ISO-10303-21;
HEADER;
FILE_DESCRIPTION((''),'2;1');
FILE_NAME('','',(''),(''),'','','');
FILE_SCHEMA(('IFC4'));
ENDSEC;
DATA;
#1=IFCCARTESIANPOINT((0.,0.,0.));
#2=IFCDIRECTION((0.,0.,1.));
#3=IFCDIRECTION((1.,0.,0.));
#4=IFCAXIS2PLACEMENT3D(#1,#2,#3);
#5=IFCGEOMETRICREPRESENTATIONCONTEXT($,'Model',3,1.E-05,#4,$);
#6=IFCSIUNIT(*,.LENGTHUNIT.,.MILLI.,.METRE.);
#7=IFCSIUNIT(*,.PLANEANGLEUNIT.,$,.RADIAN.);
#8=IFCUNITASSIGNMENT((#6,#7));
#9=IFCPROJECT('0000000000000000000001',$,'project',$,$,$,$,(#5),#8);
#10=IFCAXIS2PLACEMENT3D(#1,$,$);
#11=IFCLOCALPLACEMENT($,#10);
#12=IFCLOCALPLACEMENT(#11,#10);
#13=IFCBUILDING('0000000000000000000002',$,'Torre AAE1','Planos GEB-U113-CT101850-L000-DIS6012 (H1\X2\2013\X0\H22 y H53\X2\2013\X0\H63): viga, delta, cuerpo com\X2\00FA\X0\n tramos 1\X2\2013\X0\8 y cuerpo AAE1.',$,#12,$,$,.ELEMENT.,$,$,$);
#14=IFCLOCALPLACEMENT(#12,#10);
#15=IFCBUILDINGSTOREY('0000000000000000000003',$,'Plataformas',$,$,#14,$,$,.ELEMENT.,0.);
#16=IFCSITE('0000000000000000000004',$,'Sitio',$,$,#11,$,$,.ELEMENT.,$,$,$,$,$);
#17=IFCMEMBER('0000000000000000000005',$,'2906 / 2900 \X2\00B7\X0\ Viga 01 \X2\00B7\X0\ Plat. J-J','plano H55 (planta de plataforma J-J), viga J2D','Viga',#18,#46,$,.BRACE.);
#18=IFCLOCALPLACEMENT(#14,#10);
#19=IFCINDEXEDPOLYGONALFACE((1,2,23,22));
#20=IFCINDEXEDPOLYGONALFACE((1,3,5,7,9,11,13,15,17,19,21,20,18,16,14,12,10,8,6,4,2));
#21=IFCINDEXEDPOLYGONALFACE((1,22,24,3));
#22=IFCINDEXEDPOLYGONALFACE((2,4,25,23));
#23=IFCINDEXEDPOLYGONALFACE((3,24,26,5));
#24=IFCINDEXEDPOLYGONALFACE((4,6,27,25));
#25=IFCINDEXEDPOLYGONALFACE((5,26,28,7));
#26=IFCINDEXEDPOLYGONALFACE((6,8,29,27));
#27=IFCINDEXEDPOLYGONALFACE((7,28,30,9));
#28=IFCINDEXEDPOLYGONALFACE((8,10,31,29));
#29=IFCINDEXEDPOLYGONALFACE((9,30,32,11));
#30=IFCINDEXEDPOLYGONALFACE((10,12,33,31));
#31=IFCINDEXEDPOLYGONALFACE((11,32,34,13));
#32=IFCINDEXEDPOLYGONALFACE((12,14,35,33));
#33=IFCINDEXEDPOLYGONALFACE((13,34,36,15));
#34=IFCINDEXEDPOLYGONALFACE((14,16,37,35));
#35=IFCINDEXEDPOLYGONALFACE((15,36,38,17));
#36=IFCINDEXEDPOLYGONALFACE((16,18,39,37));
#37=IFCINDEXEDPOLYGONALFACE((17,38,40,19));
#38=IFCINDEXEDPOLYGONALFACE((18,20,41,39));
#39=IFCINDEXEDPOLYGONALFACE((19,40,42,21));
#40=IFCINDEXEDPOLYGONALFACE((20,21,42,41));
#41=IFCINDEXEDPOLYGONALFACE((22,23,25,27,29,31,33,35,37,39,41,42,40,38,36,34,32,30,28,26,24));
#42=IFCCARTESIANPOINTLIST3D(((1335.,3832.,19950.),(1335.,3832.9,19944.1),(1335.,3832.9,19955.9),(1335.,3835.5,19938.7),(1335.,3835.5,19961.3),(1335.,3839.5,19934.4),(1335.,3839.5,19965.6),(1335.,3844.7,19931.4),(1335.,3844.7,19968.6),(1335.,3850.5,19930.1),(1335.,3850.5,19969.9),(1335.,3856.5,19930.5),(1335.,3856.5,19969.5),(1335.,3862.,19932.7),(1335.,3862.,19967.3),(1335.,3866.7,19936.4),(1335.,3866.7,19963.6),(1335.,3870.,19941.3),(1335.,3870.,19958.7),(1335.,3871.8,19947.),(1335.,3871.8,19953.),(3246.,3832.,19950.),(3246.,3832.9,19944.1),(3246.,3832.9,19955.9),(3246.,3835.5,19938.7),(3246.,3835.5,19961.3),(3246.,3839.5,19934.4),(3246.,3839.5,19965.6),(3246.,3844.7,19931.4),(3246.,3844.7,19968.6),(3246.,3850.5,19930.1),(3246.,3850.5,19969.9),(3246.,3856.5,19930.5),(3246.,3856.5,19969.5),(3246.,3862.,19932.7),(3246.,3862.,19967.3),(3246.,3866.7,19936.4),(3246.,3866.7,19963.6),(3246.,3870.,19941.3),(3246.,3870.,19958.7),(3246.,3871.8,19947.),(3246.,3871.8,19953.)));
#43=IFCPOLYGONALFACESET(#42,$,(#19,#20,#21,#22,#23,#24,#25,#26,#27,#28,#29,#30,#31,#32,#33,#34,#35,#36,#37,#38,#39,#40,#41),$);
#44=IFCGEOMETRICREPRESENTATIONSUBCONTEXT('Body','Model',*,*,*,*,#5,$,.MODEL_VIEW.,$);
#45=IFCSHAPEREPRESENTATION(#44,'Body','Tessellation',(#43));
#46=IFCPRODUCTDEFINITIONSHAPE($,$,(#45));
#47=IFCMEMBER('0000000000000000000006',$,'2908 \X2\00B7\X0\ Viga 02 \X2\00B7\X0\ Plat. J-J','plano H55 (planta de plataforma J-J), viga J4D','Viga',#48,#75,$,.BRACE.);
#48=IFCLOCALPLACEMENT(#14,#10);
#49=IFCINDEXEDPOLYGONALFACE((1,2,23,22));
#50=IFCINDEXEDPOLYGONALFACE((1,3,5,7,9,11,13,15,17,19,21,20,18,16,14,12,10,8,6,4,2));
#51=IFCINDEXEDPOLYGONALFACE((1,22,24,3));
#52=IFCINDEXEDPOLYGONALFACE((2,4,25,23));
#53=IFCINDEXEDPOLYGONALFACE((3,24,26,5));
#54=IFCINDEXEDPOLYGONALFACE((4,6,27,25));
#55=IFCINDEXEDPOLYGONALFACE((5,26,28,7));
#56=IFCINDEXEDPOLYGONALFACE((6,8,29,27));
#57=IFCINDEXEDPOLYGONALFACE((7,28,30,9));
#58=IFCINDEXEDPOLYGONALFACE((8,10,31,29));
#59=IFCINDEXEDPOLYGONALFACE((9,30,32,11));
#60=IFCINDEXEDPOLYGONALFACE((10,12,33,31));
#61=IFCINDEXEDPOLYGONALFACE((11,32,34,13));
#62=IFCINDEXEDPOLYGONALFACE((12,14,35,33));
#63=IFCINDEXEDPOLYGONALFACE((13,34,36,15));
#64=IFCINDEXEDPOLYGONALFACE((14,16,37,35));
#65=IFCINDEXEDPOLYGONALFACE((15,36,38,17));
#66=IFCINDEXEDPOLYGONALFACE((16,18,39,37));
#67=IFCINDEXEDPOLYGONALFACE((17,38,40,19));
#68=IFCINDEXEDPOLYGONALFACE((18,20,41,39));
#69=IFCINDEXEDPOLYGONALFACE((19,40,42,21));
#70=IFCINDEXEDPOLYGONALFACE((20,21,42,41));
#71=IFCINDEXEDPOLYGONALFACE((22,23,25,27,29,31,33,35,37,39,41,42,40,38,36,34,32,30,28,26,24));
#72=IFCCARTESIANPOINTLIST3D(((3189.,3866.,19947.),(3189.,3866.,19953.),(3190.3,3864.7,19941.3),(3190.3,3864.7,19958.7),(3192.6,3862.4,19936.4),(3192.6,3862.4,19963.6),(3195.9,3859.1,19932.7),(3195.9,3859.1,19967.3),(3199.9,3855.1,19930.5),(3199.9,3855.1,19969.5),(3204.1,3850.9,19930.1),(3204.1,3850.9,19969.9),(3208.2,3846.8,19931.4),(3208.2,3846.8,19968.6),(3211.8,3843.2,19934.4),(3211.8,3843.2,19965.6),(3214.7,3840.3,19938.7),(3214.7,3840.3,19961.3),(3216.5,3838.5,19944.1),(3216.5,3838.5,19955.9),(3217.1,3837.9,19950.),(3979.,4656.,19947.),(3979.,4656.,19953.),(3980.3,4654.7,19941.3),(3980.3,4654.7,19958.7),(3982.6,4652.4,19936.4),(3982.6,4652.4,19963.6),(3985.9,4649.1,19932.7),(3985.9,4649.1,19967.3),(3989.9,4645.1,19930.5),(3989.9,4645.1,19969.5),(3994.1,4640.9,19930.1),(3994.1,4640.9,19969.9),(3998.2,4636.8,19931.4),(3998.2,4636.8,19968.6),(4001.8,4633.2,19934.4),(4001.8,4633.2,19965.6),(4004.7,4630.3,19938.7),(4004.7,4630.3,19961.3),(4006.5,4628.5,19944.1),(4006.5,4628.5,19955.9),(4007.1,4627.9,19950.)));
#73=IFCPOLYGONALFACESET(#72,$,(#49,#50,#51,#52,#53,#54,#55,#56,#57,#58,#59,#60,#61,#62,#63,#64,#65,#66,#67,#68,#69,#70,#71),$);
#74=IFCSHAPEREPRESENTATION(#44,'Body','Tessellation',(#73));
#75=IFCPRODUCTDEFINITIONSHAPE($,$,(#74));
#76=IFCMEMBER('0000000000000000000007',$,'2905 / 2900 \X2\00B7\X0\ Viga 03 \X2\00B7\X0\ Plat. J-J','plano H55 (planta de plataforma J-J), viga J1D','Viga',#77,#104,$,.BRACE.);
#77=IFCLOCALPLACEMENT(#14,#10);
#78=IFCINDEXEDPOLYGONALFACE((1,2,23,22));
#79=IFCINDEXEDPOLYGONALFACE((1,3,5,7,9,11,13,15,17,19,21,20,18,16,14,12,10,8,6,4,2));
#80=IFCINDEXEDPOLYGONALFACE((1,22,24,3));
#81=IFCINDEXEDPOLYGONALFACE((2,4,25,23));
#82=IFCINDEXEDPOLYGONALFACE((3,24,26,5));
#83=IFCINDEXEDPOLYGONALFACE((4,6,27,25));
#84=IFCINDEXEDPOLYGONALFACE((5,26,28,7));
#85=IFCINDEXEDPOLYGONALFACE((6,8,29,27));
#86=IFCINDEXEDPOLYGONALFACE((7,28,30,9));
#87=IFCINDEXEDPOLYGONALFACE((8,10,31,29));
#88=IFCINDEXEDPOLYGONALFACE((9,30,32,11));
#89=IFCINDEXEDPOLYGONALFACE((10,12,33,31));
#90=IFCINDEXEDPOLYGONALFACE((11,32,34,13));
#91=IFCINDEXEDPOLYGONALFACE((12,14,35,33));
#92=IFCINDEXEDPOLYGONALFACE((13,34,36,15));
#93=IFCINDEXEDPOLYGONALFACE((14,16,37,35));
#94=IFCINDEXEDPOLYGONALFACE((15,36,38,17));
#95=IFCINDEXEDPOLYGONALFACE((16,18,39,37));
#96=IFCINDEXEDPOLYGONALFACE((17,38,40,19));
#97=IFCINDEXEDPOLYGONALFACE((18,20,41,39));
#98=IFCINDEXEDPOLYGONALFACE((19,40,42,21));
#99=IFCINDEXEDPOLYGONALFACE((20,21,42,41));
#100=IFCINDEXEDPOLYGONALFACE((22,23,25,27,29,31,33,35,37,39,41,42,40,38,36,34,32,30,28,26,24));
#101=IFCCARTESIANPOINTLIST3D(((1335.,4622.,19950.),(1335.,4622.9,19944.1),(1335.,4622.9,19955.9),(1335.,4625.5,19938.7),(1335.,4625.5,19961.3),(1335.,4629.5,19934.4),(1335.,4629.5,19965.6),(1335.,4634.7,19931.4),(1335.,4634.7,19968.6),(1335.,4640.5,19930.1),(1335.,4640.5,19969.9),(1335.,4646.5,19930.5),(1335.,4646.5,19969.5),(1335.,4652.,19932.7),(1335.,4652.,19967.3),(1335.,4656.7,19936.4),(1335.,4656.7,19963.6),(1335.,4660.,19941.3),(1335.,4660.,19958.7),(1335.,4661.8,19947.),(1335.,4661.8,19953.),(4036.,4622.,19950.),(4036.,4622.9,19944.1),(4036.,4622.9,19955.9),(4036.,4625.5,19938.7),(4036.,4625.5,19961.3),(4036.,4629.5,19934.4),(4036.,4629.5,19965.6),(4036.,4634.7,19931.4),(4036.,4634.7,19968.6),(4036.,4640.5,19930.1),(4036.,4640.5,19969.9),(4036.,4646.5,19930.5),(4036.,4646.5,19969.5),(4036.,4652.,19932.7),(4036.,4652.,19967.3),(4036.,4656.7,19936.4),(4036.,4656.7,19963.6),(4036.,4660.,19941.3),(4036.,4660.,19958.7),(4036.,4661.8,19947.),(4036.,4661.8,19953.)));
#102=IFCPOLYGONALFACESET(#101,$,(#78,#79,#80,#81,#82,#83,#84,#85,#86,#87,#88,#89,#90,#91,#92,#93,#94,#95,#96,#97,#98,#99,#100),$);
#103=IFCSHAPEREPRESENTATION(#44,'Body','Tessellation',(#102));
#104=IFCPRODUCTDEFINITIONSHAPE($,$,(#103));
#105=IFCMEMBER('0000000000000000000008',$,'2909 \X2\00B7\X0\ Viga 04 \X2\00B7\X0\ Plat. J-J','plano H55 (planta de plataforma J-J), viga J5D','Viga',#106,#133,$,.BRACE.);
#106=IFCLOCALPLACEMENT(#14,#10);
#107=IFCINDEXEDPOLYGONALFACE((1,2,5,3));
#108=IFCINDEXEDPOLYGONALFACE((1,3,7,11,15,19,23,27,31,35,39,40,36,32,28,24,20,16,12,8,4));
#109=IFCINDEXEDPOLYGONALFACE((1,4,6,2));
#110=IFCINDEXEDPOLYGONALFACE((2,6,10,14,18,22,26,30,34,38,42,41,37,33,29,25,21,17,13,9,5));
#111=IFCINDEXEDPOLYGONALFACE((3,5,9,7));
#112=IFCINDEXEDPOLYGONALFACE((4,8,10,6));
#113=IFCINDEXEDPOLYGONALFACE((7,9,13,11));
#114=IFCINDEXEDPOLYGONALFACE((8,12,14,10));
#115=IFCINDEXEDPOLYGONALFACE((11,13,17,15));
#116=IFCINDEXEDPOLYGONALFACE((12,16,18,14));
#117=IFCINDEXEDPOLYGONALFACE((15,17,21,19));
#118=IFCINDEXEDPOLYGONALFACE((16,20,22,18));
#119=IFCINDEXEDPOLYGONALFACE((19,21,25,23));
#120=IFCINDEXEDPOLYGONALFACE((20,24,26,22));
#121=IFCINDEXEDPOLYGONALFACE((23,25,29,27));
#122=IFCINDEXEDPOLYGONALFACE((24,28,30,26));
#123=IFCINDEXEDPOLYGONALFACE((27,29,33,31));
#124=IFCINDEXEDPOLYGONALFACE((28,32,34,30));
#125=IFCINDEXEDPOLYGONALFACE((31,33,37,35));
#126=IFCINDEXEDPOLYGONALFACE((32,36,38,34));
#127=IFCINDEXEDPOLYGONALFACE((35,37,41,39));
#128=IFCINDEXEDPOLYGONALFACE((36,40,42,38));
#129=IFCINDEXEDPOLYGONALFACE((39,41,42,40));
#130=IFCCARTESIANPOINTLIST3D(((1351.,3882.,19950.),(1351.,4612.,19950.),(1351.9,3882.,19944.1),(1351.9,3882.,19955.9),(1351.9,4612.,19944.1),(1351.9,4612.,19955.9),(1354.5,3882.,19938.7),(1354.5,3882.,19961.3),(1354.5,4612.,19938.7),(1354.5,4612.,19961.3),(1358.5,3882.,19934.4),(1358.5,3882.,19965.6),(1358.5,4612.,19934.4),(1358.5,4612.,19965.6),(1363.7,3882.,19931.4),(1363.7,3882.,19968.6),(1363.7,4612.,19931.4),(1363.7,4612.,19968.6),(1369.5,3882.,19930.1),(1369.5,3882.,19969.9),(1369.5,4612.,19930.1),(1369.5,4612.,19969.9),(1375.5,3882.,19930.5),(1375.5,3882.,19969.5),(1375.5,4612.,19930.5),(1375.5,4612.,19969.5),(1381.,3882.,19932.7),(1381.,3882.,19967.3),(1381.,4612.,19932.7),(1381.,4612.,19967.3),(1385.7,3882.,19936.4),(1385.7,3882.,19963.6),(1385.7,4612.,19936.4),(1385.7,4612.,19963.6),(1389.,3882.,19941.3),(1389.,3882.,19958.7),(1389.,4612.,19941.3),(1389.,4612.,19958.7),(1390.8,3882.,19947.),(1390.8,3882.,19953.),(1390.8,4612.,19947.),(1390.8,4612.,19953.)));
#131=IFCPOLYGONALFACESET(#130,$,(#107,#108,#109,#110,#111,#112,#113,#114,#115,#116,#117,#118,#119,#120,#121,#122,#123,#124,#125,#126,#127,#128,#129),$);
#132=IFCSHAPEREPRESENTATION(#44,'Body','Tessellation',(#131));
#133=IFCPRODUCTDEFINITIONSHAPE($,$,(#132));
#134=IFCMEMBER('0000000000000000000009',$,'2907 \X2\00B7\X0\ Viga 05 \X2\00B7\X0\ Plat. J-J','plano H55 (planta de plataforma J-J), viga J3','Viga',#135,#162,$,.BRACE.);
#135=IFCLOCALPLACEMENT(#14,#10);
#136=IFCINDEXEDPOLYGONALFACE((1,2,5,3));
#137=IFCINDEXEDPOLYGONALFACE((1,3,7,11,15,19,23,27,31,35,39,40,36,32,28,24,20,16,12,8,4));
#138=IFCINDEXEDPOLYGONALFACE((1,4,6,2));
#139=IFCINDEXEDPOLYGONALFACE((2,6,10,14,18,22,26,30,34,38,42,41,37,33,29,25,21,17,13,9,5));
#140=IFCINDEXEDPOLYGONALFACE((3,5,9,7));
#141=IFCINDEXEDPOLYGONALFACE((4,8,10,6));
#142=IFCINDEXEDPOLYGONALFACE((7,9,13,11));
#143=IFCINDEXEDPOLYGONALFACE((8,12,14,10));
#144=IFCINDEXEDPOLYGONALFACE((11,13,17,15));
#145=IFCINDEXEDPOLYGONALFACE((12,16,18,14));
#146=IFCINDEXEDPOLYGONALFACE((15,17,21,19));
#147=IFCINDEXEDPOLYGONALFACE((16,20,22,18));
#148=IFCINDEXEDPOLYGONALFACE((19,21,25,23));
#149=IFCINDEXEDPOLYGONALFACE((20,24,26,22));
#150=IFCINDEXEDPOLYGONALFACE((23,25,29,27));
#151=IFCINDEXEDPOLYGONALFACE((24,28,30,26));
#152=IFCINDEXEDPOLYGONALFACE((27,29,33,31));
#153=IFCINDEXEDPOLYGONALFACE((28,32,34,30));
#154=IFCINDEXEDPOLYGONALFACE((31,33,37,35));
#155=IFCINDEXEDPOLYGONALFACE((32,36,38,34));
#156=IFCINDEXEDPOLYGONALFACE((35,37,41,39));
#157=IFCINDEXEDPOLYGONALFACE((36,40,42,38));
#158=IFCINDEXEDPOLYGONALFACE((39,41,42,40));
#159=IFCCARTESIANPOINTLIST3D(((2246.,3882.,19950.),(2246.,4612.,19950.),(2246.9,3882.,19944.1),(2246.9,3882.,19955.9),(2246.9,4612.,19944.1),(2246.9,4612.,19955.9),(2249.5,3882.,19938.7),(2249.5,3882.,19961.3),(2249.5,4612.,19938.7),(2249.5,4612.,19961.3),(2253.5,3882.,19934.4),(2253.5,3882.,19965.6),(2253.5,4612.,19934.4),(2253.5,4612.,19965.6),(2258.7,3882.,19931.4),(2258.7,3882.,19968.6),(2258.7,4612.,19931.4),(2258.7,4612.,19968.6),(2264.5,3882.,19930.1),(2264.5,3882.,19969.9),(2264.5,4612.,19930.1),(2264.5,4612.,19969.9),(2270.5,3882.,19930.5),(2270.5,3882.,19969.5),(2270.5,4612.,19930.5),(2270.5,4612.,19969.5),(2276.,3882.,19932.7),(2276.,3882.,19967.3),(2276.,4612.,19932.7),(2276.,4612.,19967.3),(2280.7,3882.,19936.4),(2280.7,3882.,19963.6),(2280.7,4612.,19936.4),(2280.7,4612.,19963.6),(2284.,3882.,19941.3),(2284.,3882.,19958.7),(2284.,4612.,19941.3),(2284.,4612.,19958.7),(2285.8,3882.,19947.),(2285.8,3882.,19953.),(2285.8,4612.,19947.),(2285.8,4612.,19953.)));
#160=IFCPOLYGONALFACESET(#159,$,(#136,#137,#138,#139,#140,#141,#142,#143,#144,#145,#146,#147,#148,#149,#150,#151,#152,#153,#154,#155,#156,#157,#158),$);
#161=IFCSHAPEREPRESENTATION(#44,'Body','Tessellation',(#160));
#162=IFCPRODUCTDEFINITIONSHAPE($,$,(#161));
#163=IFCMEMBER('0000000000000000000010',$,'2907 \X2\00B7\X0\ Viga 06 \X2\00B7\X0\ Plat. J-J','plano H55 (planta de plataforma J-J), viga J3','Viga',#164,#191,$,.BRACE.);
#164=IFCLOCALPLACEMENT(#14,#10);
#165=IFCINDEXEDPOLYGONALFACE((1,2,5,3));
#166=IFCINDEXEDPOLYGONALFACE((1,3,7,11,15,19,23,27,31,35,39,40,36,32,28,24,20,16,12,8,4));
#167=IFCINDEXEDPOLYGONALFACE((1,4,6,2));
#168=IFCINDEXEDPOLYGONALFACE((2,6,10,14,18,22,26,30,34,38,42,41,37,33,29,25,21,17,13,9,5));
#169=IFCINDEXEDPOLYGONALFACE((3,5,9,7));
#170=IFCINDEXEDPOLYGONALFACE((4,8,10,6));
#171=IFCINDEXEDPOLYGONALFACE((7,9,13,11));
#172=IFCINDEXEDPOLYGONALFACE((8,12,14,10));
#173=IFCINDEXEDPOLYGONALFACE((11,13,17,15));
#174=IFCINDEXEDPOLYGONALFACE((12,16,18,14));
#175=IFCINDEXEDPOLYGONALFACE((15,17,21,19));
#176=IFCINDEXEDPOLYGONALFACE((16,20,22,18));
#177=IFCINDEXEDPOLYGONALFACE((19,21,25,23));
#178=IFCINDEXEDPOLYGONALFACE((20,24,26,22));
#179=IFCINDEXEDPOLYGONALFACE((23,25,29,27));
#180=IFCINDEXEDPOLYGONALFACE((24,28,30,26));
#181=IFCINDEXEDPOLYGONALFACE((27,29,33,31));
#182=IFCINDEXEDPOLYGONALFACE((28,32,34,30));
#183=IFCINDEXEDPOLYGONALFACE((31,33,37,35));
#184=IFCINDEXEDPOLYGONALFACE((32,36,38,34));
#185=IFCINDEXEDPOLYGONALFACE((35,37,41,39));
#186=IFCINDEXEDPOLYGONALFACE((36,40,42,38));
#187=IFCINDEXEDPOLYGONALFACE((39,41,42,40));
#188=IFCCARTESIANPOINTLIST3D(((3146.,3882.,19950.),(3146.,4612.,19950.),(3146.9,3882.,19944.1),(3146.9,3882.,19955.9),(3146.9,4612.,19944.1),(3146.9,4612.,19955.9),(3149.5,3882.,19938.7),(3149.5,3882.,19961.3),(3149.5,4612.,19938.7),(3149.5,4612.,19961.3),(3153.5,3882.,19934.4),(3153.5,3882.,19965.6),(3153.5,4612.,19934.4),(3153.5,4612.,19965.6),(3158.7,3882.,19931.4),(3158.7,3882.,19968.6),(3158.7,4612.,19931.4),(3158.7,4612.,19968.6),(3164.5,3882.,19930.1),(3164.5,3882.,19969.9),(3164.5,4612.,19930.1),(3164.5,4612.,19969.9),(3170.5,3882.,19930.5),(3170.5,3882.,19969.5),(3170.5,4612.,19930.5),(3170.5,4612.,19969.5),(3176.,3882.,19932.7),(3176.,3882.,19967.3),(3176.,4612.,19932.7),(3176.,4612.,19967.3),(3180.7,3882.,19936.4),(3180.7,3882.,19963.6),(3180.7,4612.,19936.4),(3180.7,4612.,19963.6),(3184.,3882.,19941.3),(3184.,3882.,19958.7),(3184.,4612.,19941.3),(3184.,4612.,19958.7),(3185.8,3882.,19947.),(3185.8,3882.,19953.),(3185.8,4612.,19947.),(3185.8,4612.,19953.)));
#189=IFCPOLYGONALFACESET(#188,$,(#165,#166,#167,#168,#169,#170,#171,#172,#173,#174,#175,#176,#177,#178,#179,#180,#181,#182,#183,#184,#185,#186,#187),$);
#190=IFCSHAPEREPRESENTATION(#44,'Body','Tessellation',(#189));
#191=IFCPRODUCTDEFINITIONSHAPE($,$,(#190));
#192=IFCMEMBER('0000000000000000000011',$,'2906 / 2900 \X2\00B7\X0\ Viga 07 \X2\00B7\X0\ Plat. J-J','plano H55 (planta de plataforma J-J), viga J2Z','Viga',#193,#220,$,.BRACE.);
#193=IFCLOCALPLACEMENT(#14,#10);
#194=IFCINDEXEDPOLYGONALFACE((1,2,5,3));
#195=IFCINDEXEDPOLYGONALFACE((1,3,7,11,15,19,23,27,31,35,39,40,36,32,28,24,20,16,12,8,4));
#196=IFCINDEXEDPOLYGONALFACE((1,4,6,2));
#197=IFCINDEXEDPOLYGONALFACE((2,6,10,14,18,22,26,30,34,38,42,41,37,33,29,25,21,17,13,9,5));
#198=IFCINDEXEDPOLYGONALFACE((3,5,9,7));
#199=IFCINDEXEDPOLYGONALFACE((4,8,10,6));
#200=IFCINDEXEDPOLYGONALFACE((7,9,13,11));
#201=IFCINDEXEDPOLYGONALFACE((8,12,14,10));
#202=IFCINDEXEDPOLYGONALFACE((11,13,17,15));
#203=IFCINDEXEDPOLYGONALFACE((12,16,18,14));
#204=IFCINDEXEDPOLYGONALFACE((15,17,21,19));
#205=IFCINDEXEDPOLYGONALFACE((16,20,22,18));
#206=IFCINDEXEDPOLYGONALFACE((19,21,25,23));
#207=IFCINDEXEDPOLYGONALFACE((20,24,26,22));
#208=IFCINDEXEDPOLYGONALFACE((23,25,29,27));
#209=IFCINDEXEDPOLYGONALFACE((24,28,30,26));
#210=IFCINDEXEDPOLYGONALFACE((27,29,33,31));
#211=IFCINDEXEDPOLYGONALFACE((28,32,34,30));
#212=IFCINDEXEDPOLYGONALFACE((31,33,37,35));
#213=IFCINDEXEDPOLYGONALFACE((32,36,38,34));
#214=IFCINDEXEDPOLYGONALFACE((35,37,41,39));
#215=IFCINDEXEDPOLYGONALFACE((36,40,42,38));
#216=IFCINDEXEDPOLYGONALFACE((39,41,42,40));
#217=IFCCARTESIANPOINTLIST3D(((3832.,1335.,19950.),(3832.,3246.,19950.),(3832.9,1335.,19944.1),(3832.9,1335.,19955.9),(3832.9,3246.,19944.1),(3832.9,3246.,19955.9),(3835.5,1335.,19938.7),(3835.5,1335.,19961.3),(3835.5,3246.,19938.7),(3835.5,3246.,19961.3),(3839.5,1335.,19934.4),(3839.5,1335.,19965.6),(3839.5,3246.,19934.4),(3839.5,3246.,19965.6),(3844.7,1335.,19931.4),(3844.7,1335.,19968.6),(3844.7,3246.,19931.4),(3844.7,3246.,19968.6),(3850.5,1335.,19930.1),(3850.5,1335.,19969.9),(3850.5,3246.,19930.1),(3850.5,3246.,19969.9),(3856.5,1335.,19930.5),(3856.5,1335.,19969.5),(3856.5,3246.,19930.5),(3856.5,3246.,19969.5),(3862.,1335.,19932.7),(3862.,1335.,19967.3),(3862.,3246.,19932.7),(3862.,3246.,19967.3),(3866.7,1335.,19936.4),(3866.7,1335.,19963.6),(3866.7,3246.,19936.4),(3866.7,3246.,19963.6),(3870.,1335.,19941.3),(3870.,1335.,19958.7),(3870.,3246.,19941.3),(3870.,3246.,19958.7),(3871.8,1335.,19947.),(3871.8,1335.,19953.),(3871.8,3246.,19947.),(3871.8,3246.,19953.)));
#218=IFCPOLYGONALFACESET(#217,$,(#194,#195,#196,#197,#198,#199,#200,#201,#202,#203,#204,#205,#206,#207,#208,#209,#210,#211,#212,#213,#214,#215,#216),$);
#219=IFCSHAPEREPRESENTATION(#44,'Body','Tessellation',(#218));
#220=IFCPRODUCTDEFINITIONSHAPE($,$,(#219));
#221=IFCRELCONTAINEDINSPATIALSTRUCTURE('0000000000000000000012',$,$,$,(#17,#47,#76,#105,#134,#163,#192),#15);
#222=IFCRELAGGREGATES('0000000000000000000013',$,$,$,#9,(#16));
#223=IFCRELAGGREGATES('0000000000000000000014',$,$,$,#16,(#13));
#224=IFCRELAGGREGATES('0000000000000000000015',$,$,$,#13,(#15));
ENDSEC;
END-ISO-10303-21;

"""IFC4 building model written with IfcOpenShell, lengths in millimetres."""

from ifc_helpers import new_model, si_unit, frame, origin, origin_with_axes, place, context, subcontext, project, spatial, circle, extrude, element, save


model = new_model("IFC4")

# Units and contexts
model_context = context("Model", 3, precision=1e-05, world=origin_with_axes())
body_context = subcontext(model_context, "Body", "Model", "MODEL_VIEW")
ifc_project = project(units=[si_unit("LENGTHUNIT", "METRE", prefix="MILLI"), si_unit("PLANEANGLEUNIT", "RADIAN")], contexts=[model_context])

# Site, building, storey
site_placement = place(None, origin())
site = spatial("IfcSite", under=ifc_project, at=site_placement, Name="Sitio", CompositionType="ELEMENT")
building_placement = place(site_placement, origin())
building = spatial("IfcBuilding", under=site, at=building_placement, Name="Torre AAE1", Description="Planos GEB-U113-CT101850-L000-DIS6012 (H1–H22 y H53–H63): viga, delta, cuerpo común tramos 1–8 y cuerpo AAE1.", CompositionType="ELEMENT")
storey_placement = place(building_placement, origin())
storey = spatial("IfcBuildingStorey", under=building, at=storey_placement, Name="Plataformas", CompositionType="ELEMENT", Elevation=0.0)

# Members
member_1_placement = place(storey_placement, frame((1335.0, 3852.0, 19950.0), z_axis=(1.0, 0.0, 0.0), x_axis=(0.0, -1.0, 0.0)))
element("IfcMember", 1, at=member_1_placement, inside=storey, Name="2906 / 2900 · Viga 01 · Plat. J-J", Description="plano H55 (planta de plataforma J-J), viga J2D", ObjectType="Viga", PredefinedType="BRACE", context=body_context, shape_type="SweptSolid", body=[
    extrude(circle(Radius=20.0), None, (0.0, 0.0, 1.0), 1911.0),
])
member_2_placement = place(storey_placement, frame((3993.0, 4642.0, 19950.0), z_axis=(-0.707107, -0.707107, 0.0), x_axis=(0.707107, -0.707107, 0.0)))
element("IfcMember", 2, at=member_2_placement, inside=storey, Name="2908 · Viga 02 · Plat. J-J", Description="plano H55 (planta de plataforma J-J), viga J4D", ObjectType="Viga", PredefinedType="BRACE", context=body_context, shape_type="SweptSolid", body=[
    extrude(circle(Radius=20.0), None, (0.0, 0.0, 1.0), 1117.2),
])
member_3_placement = place(storey_placement, frame((4036.0, 4642.0, 19950.0), z_axis=(-1.0, 0.0, 0.0), x_axis=(0.0, -1.0, 0.0)))
element("IfcMember", 3, at=member_3_placement, inside=storey, Name="2905 / 2900 · Viga 03 · Plat. J-J", Description="plano H55 (planta de plataforma J-J), viga J1D", ObjectType="Viga", PredefinedType="BRACE", context=body_context, shape_type="SweptSolid", body=[
    extrude(circle(Radius=20.0), None, (0.0, 0.0, 1.0), 2701.0),
])
for number, where, z_axis, x_axis, name, description in (
    (4, (1371.0, 4612.0, 19950.0), (0.0, -1.0, 0.0), (-1.0, 0.0, 0.0), "2909 · Viga 04 · Plat. J-J", "plano H55 (planta de plataforma J-J), viga J5D"),
    (5, (2266.0, 4612.0, 19950.0), (0.0, -1.0, 0.0), (-1.0, 0.0, 0.0), "2907 · Viga 05 · Plat. J-J", "plano H55 (planta de plataforma J-J), viga J3"),
    (6, (3166.0, 4612.0, 19950.0), (0.0, -1.0, 0.0), (-1.0, 0.0, 0.0), "2907 · Viga 06 · Plat. J-J", "plano H55 (planta de plataforma J-J), viga J3"),
):
    element("IfcMember", number, at=place(storey_placement, frame(where, z_axis=z_axis, x_axis=x_axis)), inside=storey, Name=name, Description=description, ObjectType="Viga", PredefinedType="BRACE", context=body_context, shape_type="SweptSolid", body=[
        extrude(circle(Radius=20.0), None, (0.0, 0.0, 1.0), 730.0),
    ])
member_4_placement = place(storey_placement, frame((3852.0, 1335.0, 19950.0), z_axis=(0.0, 1.0, 0.0), x_axis=(-1.0, 0.0, 0.0)))
element("IfcMember", 7, at=member_4_placement, inside=storey, Name="2906 / 2900 · Viga 07 · Plat. J-J", Description="plano H55 (planta de plataforma J-J), viga J2Z", ObjectType="Viga", PredefinedType="BRACE", context=body_context, shape_type="SweptSolid", body=[
    extrude(circle(Radius=20.0), None, (0.0, 0.0, 1.0), 1911.0),
])

save(model, "model.ifc")
